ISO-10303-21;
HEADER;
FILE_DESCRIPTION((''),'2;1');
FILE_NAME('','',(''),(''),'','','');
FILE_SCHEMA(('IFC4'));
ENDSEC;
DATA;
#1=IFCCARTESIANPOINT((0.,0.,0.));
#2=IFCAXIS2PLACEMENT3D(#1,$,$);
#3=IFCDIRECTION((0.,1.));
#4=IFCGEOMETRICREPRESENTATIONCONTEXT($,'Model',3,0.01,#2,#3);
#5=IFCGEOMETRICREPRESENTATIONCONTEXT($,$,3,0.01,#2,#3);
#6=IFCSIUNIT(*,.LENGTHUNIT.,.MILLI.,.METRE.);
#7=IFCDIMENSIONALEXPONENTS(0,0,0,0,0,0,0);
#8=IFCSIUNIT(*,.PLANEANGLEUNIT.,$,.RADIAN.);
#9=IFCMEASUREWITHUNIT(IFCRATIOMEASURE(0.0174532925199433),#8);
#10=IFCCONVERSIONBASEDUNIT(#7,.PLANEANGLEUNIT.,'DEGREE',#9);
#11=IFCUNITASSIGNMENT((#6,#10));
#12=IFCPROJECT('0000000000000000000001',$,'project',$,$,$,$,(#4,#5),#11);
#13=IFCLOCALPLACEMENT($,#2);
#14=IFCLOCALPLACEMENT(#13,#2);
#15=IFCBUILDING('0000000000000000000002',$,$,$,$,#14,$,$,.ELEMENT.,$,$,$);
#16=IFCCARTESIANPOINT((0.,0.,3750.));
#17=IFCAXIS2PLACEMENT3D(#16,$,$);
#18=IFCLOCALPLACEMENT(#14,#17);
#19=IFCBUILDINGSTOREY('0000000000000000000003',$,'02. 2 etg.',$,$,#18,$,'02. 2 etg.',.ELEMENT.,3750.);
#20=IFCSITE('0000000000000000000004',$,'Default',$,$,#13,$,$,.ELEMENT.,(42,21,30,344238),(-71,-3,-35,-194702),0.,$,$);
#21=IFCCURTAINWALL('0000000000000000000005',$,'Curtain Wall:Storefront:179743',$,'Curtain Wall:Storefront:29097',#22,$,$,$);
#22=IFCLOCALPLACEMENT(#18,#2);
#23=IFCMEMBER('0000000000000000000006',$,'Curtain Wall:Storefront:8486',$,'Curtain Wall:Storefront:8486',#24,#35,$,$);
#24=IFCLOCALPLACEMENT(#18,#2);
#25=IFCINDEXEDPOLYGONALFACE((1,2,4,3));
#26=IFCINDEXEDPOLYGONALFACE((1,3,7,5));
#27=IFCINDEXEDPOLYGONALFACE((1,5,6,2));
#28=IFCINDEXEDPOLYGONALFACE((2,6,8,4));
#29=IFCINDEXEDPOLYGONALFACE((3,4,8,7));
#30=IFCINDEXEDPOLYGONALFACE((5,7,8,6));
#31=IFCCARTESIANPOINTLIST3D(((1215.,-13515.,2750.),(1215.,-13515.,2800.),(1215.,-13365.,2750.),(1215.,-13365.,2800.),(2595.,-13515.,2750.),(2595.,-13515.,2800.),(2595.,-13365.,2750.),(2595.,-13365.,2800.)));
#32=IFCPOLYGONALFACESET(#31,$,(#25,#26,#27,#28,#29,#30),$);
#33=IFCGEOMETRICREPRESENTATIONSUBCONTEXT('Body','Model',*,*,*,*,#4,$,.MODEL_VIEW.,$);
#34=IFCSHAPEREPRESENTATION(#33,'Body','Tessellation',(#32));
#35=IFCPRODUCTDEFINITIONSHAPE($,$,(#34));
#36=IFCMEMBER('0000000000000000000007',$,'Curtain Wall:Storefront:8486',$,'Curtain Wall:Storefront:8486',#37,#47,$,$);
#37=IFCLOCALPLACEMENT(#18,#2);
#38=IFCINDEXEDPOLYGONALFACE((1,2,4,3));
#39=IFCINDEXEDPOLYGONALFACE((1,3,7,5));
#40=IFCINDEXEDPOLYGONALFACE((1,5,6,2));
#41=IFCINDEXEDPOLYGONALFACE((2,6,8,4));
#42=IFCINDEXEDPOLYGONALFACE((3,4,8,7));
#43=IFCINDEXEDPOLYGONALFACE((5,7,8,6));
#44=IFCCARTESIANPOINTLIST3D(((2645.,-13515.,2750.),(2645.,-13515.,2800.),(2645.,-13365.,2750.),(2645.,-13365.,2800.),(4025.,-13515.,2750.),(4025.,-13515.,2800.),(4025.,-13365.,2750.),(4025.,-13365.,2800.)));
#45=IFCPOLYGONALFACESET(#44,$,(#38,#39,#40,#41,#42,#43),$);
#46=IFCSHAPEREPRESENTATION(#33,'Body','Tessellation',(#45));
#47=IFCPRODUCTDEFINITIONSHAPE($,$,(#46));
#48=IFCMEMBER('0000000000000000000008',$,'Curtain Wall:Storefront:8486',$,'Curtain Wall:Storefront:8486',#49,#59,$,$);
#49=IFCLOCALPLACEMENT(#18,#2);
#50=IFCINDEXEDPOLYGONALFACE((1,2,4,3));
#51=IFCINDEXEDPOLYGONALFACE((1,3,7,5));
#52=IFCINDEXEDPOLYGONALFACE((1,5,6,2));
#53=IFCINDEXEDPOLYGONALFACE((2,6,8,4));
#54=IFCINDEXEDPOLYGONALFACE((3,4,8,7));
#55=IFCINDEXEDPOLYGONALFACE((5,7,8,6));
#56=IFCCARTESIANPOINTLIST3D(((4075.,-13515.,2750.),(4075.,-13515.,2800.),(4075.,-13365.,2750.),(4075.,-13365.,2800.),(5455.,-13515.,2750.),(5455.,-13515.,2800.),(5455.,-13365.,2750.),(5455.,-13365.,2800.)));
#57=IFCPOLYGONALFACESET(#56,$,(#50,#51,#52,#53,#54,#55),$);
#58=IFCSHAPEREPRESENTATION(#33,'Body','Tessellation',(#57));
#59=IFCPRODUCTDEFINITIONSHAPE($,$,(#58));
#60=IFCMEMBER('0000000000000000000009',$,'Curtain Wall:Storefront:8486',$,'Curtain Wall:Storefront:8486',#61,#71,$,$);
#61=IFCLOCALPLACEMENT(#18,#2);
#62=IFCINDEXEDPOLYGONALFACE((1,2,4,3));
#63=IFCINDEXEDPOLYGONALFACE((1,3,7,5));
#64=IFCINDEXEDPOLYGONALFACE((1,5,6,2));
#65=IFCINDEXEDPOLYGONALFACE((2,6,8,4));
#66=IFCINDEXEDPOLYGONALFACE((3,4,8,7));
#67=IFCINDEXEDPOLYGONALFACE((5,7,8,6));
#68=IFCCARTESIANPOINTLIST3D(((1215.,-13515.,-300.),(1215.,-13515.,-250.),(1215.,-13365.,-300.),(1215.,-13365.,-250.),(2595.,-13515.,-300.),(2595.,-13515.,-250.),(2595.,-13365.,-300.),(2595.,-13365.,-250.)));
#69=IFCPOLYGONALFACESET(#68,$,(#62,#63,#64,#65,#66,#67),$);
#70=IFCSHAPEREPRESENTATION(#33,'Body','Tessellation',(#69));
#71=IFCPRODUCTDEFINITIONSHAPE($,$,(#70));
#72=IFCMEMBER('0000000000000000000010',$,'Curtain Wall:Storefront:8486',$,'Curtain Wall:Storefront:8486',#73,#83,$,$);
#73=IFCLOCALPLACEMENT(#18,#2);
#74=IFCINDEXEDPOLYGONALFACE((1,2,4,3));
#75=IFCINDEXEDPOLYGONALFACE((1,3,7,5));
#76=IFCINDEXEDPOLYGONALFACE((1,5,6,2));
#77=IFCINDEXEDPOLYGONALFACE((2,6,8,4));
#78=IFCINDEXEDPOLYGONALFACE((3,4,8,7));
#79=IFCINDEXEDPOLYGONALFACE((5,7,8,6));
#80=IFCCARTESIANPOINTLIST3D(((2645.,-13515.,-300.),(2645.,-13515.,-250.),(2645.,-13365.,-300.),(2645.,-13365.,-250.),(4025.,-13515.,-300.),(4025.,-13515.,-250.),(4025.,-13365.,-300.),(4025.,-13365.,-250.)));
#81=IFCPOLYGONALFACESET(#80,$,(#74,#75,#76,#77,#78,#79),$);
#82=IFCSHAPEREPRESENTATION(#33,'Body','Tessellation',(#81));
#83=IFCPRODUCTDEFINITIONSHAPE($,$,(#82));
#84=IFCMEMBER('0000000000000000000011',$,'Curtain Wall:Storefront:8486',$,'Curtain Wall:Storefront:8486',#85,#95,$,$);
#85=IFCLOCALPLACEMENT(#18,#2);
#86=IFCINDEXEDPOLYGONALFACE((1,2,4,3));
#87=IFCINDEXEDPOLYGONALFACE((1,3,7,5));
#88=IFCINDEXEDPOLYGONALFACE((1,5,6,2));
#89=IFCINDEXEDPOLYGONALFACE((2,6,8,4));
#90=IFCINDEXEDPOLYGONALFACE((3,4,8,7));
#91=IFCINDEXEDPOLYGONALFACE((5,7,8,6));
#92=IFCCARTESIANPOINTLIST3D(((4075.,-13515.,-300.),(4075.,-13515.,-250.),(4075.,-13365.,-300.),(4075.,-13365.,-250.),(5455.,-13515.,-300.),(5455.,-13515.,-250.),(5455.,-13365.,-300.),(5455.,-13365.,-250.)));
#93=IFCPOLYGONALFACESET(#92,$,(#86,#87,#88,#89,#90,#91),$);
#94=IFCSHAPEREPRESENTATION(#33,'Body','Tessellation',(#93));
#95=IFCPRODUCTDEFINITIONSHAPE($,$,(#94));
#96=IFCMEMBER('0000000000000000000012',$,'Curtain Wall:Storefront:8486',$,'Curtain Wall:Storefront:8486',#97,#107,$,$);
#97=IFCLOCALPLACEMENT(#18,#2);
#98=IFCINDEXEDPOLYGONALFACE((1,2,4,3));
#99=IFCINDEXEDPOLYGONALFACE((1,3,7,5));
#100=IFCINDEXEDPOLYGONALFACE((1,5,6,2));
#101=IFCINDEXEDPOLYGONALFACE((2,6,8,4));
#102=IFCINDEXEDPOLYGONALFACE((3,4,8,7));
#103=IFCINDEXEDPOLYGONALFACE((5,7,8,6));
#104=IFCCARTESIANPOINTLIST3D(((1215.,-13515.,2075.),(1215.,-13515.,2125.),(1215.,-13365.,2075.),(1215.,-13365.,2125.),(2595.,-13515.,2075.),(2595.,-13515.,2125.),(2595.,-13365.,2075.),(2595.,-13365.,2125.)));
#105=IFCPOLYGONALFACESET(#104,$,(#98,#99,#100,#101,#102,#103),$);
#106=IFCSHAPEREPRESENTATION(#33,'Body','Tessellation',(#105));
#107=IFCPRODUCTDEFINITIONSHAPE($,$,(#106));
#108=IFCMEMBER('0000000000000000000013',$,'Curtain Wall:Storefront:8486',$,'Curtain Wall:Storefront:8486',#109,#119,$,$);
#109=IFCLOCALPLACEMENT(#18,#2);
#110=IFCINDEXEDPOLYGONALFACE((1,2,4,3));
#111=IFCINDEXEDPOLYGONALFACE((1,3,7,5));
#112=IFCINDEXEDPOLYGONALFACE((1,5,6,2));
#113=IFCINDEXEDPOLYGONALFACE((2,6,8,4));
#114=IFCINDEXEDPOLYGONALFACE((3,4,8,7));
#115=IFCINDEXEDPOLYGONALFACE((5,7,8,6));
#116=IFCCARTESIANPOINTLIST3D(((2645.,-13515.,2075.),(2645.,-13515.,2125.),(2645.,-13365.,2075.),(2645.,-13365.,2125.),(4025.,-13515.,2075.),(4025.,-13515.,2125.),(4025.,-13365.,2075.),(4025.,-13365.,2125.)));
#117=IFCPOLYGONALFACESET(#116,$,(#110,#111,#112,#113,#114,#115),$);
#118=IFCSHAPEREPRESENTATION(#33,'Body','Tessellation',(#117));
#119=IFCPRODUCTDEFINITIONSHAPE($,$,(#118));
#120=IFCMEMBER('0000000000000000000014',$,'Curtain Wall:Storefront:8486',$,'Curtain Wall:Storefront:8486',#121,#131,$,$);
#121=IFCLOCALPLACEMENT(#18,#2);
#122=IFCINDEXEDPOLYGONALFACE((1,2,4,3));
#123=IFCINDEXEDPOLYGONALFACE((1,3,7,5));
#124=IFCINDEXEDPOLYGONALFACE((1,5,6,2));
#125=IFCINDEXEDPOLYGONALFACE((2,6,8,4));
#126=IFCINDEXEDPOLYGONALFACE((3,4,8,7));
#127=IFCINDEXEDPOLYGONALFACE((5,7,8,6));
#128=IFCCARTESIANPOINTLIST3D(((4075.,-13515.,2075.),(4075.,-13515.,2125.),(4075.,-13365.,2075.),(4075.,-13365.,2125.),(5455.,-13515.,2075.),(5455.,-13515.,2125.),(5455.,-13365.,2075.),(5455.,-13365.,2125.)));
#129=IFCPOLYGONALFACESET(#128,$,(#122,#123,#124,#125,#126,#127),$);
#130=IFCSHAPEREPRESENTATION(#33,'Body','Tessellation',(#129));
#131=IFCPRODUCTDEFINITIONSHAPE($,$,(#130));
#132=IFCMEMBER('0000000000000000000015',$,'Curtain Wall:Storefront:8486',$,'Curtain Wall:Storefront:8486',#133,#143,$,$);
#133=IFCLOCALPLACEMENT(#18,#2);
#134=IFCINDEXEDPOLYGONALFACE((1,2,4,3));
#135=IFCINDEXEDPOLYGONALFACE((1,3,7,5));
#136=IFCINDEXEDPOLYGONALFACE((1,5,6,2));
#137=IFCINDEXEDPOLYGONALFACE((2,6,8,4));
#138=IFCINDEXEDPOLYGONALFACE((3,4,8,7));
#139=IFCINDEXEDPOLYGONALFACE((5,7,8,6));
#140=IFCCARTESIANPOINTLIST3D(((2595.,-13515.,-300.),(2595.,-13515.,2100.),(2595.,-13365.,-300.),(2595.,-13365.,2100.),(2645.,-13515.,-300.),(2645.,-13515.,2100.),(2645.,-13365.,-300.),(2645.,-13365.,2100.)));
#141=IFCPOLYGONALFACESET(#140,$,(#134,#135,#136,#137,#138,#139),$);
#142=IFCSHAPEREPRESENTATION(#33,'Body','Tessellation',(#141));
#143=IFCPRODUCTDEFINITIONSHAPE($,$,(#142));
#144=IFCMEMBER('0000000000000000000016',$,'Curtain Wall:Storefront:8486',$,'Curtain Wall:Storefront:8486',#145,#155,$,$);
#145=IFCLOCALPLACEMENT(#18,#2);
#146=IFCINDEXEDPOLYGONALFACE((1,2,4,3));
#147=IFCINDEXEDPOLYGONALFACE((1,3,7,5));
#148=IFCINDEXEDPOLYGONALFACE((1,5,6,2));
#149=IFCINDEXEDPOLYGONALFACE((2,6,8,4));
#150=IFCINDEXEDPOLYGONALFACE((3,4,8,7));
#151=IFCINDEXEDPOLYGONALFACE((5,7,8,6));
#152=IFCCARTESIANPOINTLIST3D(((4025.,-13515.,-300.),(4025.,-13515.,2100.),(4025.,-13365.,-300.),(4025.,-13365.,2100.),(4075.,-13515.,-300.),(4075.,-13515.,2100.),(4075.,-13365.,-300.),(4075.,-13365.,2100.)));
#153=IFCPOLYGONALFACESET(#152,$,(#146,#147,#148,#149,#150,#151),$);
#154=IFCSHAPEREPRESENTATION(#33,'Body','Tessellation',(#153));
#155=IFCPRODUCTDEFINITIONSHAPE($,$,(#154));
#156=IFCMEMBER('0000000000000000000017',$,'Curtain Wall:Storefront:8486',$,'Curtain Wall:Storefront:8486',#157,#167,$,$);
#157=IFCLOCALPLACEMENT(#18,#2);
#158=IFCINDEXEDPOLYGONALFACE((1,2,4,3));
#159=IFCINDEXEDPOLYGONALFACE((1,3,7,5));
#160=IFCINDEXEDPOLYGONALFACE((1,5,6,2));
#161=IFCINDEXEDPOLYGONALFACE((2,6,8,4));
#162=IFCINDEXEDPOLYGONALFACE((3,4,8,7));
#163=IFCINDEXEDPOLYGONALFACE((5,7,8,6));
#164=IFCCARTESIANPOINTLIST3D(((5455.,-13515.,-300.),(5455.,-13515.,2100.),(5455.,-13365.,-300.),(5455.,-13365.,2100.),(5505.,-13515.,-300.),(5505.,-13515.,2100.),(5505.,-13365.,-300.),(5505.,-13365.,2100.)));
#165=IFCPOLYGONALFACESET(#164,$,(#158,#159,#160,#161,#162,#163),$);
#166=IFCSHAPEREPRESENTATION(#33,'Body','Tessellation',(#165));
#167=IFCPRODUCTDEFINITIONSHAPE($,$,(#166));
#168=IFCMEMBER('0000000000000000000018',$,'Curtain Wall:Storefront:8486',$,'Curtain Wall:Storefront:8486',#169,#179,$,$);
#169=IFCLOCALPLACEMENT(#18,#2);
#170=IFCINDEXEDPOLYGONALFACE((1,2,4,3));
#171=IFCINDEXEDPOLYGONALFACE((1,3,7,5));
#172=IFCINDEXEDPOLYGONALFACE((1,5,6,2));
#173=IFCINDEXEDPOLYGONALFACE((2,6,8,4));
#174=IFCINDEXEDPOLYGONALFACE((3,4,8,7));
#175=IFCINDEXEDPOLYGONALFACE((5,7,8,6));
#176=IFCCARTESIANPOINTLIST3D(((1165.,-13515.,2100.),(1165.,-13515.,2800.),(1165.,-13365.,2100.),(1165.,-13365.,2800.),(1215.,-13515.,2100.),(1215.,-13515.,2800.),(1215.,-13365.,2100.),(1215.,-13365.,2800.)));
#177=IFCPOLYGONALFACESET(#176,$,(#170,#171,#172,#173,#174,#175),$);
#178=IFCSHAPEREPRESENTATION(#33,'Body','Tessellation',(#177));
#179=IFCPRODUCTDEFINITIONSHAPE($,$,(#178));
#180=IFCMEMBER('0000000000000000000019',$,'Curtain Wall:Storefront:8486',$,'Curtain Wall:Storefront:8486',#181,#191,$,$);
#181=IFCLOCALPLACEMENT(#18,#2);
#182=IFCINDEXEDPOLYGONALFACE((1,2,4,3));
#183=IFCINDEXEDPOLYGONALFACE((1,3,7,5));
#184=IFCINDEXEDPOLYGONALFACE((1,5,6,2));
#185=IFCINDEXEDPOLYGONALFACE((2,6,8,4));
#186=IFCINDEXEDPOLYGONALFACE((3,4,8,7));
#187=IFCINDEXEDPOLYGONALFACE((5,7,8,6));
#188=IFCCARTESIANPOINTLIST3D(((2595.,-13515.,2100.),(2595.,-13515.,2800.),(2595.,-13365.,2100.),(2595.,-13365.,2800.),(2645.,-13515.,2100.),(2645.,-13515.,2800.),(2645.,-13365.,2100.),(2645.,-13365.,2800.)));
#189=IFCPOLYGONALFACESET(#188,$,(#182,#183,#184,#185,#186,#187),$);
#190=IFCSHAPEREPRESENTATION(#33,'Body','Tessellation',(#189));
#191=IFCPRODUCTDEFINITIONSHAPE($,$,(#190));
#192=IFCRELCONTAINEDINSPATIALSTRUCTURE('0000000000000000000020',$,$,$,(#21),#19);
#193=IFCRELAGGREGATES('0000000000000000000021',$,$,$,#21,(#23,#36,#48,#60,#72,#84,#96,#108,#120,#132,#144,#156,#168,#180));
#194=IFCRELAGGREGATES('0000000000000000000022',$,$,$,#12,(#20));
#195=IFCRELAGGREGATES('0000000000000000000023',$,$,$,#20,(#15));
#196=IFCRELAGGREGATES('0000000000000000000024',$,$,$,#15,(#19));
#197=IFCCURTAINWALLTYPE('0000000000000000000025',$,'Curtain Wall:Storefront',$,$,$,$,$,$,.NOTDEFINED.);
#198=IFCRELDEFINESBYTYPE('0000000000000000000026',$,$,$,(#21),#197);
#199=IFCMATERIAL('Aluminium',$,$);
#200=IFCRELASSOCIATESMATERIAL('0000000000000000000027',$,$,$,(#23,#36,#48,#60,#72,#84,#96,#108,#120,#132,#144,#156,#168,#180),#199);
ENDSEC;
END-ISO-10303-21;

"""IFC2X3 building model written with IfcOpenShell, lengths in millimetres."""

from ifc_helpers import new_model, entity, si_unit, converted_unit, direction, frame, frame_2d, origin, origin_2d_with_axis, place, context, subcontext, project, spatial, rectangle, extrude, material, type_object, element, aggregate, save


model = new_model("IFC2X3")

# Units and contexts
model_context = context("Model", 3, precision=0.01, world=origin(), true_north=direction((0.0, 1.0)))
context_of_model = context(None, 3, precision=0.01, world=origin(), true_north=direction((0.0, 1.0)))
body_context = subcontext(model_context, "Body", "Model", "MODEL_VIEW")
ifc_project = project(units=[si_unit("LENGTHUNIT", "METRE", prefix="MILLI"), converted_unit("PLANEANGLEUNIT", "DEGREE", entity("IfcRatioMeasure", 0.0174532925199433), si_unit("PLANEANGLEUNIT", "RADIAN"), dimensions=[0, 0, 0, 0, 0, 0, 0])], contexts=[model_context, context_of_model])

# Site, building, storey
site_placement = place(None, origin())
site = spatial("IfcSite", under=ifc_project, at=site_placement, Name="Default", CompositionType="ELEMENT", RefLatitude=(42, 21, 30, 344238), RefLongitude=(-71, -3, -35, -194702), RefElevation=0.0)
building_placement = place(site_placement, origin())
building = spatial("IfcBuilding", under=site, at=building_placement, CompositionType="ELEMENT")
storey_placement = place(building_placement, frame((0.0, 0.0, 3750.0)))
storey = spatial("IfcBuildingStorey", under=building, at=storey_placement, Name="02. 2 etg.", LongName="02. 2 etg.", CompositionType="ELEMENT", Elevation=3750.0)

# Curtain wall, members
curtain_wall_type = type_object("IfcCurtainWallType", Name="Curtain Wall:Storefront", PredefinedType="NOTDEFINED")
curtain_wall_placement = place(storey_placement, frame((0.0, 0.0, -3750.0)))
curtain_wall = element("IfcCurtainWall", 1, at=curtain_wall_placement, inside=storey, type_object=curtain_wall_type, Name="Curtain Wall:Storefront:179743", ObjectType="Curtain Wall:Storefront:29097")
ifc_material_1 = material(Name="Aluminium")
member_1_placement = place(curtain_wall_placement, frame((1215.0, -13515.0, 6500.0)))
member_1 = element("IfcMember", 2, at=member_1_placement, material=ifc_material_1, Name="Curtain Wall:Storefront:8486", ObjectType="Curtain Wall:Storefront:8486", context=body_context, shape_type="SweptSolid", body=[
    extrude(rectangle(XDim=1380.0, YDim=150.0, at=frame_2d((0.0, 0.0), x_axis=(1.0, 0.0))), frame((690.0, 75.0, 0.0), z_axis=(0.0, 0.0, 1.0), x_axis=(-1.0, 0.0, 0.0)), (0.0, 0.0, 1.0), 50.0),
])
member_2_placement = place(curtain_wall_placement, frame((2645.0, -13515.0, 6500.0)))
member_2 = element("IfcMember", 3, at=member_2_placement, material=ifc_material_1, Name="Curtain Wall:Storefront:8486", ObjectType="Curtain Wall:Storefront:8486", context=body_context, shape_type="SweptSolid", body=[
    extrude(rectangle(XDim=1380.0, YDim=150.0, at=frame_2d((0.0, 0.0), x_axis=(1.0, 0.0))), frame((690.0, 75.0, 0.0), z_axis=(0.0, 0.0, 1.0), x_axis=(-1.0, 0.0, 0.0)), (0.0, 0.0, 1.0), 50.0),
])
member_3_placement = place(curtain_wall_placement, frame((4075.0, -13515.0, 6500.0)))
member_3 = element("IfcMember", 4, at=member_3_placement, material=ifc_material_1, Name="Curtain Wall:Storefront:8486", ObjectType="Curtain Wall:Storefront:8486", context=body_context, shape_type="SweptSolid", body=[
    extrude(rectangle(XDim=1380.0, YDim=150.0, at=frame_2d((0.0, 0.0), x_axis=(1.0, 0.0))), frame((690.0, 75.0, 0.0), z_axis=(0.0, 0.0, 1.0), x_axis=(-1.0, 0.0, 0.0)), (0.0, 0.0, 1.0), 50.0),
])
member_4_placement = place(curtain_wall_placement, frame((1215.0, -13515.0, 3450.0)))
member_4 = element("IfcMember", 5, at=member_4_placement, material=ifc_material_1, Name="Curtain Wall:Storefront:8486", ObjectType="Curtain Wall:Storefront:8486", context=body_context, shape_type="SweptSolid", body=[
    extrude(rectangle(XDim=1380.0, YDim=150.0, at=frame_2d((0.0, 0.0), x_axis=(1.0, 0.0))), frame((690.0, 75.0, 0.0)), (0.0, 0.0, 1.0), 50.0),
])
member_5_placement = place(curtain_wall_placement, frame((2645.0, -13515.0, 3450.0)))
member_5 = element("IfcMember", 6, at=member_5_placement, material=ifc_material_1, Name="Curtain Wall:Storefront:8486", ObjectType="Curtain Wall:Storefront:8486", context=body_context, shape_type="SweptSolid", body=[
    extrude(rectangle(XDim=1380.0, YDim=150.0, at=frame_2d((0.0, 0.0), x_axis=(1.0, 0.0))), frame((690.0, 75.0, 0.0)), (0.0, 0.0, 1.0), 50.0),
])
member_6_placement = place(curtain_wall_placement, frame((4075.0, -13515.0, 3450.0)))
member_6 = element("IfcMember", 7, at=member_6_placement, material=ifc_material_1, Name="Curtain Wall:Storefront:8486", ObjectType="Curtain Wall:Storefront:8486", context=body_context, shape_type="SweptSolid", body=[
    extrude(rectangle(XDim=1380.0, YDim=150.0, at=frame_2d((0.0, 0.0), x_axis=(1.0, 0.0))), frame((690.0, 75.0, 0.0)), (0.0, 0.0, 1.0), 50.0),
])
member_7_placement = place(curtain_wall_placement, frame((1215.0, -13515.0, 5825.0)))
member_7 = element("IfcMember", 8, at=member_7_placement, material=ifc_material_1, Name="Curtain Wall:Storefront:8486", ObjectType="Curtain Wall:Storefront:8486", context=body_context, shape_type="SweptSolid", body=[
    extrude(rectangle(XDim=1380.0, YDim=150.0, at=frame_2d((0.0, 0.0), x_axis=(1.0, 0.0))), frame((690.0, 75.0, 0.0), z_axis=(0.0, 0.0, 1.0), x_axis=(-1.0, 0.0, 0.0)), (0.0, 0.0, 1.0), 50.0),
])
member_8_placement = place(curtain_wall_placement, frame((2645.0, -13515.0, 5825.0)))
member_8 = element("IfcMember", 9, at=member_8_placement, material=ifc_material_1, Name="Curtain Wall:Storefront:8486", ObjectType="Curtain Wall:Storefront:8486", context=body_context, shape_type="SweptSolid", body=[
    extrude(rectangle(XDim=1380.0, YDim=150.0, at=origin_2d_with_axis()), frame((690.0, 75.0, 0.0), z_axis=(0.0, 0.0, 1.0), x_axis=(-1.0, 0.0, 0.0)), (0.0, 0.0, 1.0), 50.0),
])
member_9_placement = place(curtain_wall_placement, frame((4075.0, -13515.0, 5825.0)))
member_9 = element("IfcMember", 10, at=member_9_placement, material=ifc_material_1, Name="Curtain Wall:Storefront:8486", ObjectType="Curtain Wall:Storefront:8486", context=body_context, shape_type="SweptSolid", body=[
    extrude(rectangle(XDim=1380.0, YDim=150.0, at=origin_2d_with_axis()), frame((690.0, 75.0, 0.0), z_axis=(0.0, 0.0, 1.0), x_axis=(-1.0, 0.0, 0.0)), (0.0, 0.0, 1.0), 50.0),
])
member_10_placement = place(curtain_wall_placement, frame((2595.0, -13515.0, 3450.0)))
member_10 = element("IfcMember", 11, at=member_10_placement, material=ifc_material_1, Name="Curtain Wall:Storefront:8486", ObjectType="Curtain Wall:Storefront:8486", context=body_context, shape_type="SweptSolid", body=[
    extrude(rectangle(XDim=150.0, YDim=50.0, at=frame_2d((0.0, 0.0), x_axis=(1.0, 0.0))), frame((25.0, 75.0, 0.0), z_axis=(0.0, 0.0, 1.0), x_axis=(0.0, 1.0, 0.0)), (0.0, 0.0, 1.0), 2400.0),
])
member_11_placement = place(curtain_wall_placement, frame((4025.0, -13515.0, 3450.0)))
member_11 = element("IfcMember", 12, at=member_11_placement, material=ifc_material_1, Name="Curtain Wall:Storefront:8486", ObjectType="Curtain Wall:Storefront:8486", context=body_context, shape_type="SweptSolid", body=[
    extrude(rectangle(XDim=150.0, YDim=50.0, at=frame_2d((0.0, 0.0), x_axis=(1.0, 0.0))), frame((25.0, 75.0, 0.0), z_axis=(0.0, 0.0, 1.0), x_axis=(0.0, 1.0, 0.0)), (0.0, 0.0, 1.0), 2400.0),
])
member_12_placement = place(curtain_wall_placement, frame((5455.0, -13515.0, 3450.0)))
member_12 = element("IfcMember", 13, at=member_12_placement, material=ifc_material_1, Name="Curtain Wall:Storefront:8486", ObjectType="Curtain Wall:Storefront:8486", context=body_context, shape_type="SweptSolid", body=[
    extrude(rectangle(XDim=150.0, YDim=50.0, at=frame_2d((0.0, 0.0), x_axis=(1.0, 0.0))), frame((25.0, 75.0, 0.0), z_axis=(0.0, 0.0, 1.0), x_axis=(0.0, 1.0, 0.0)), (0.0, 0.0, 1.0), 2400.0),
])
member_13_placement = place(curtain_wall_placement, frame((1165.0, -13515.0, 5850.0)))
member_13 = element("IfcMember", 14, at=member_13_placement, material=ifc_material_1, Name="Curtain Wall:Storefront:8486", ObjectType="Curtain Wall:Storefront:8486", context=body_context, shape_type="SweptSolid", body=[
    extrude(rectangle(XDim=150.0, YDim=50.0, at=origin_2d_with_axis()), frame((25.0, 75.0, 0.0), z_axis=(0.0, 0.0, 1.0), x_axis=(0.0, 1.0, 0.0)), (0.0, 0.0, 1.0), 700.0),
])
member_14_placement = place(curtain_wall_placement, frame((2595.0, -13515.0, 5850.0)))
member_14 = element("IfcMember", 15, at=member_14_placement, material=ifc_material_1, Name="Curtain Wall:Storefront:8486", ObjectType="Curtain Wall:Storefront:8486", context=body_context, shape_type="SweptSolid", body=[
    extrude(rectangle(XDim=150.0, YDim=50.0, at=frame_2d((0.0, 0.0), x_axis=(1.0, 0.0))), frame((25.0, 75.0, 0.0), z_axis=(0.0, 0.0, 1.0), x_axis=(0.0, 1.0, 0.0)), (0.0, 0.0, 1.0), 700.0),
])
aggregate(curtain_wall, [member_1, member_2, member_3, member_4, member_5, member_6, member_7, member_8, member_9, member_10, member_11, member_12, member_13, member_14])

save(model, "model.ifc")
